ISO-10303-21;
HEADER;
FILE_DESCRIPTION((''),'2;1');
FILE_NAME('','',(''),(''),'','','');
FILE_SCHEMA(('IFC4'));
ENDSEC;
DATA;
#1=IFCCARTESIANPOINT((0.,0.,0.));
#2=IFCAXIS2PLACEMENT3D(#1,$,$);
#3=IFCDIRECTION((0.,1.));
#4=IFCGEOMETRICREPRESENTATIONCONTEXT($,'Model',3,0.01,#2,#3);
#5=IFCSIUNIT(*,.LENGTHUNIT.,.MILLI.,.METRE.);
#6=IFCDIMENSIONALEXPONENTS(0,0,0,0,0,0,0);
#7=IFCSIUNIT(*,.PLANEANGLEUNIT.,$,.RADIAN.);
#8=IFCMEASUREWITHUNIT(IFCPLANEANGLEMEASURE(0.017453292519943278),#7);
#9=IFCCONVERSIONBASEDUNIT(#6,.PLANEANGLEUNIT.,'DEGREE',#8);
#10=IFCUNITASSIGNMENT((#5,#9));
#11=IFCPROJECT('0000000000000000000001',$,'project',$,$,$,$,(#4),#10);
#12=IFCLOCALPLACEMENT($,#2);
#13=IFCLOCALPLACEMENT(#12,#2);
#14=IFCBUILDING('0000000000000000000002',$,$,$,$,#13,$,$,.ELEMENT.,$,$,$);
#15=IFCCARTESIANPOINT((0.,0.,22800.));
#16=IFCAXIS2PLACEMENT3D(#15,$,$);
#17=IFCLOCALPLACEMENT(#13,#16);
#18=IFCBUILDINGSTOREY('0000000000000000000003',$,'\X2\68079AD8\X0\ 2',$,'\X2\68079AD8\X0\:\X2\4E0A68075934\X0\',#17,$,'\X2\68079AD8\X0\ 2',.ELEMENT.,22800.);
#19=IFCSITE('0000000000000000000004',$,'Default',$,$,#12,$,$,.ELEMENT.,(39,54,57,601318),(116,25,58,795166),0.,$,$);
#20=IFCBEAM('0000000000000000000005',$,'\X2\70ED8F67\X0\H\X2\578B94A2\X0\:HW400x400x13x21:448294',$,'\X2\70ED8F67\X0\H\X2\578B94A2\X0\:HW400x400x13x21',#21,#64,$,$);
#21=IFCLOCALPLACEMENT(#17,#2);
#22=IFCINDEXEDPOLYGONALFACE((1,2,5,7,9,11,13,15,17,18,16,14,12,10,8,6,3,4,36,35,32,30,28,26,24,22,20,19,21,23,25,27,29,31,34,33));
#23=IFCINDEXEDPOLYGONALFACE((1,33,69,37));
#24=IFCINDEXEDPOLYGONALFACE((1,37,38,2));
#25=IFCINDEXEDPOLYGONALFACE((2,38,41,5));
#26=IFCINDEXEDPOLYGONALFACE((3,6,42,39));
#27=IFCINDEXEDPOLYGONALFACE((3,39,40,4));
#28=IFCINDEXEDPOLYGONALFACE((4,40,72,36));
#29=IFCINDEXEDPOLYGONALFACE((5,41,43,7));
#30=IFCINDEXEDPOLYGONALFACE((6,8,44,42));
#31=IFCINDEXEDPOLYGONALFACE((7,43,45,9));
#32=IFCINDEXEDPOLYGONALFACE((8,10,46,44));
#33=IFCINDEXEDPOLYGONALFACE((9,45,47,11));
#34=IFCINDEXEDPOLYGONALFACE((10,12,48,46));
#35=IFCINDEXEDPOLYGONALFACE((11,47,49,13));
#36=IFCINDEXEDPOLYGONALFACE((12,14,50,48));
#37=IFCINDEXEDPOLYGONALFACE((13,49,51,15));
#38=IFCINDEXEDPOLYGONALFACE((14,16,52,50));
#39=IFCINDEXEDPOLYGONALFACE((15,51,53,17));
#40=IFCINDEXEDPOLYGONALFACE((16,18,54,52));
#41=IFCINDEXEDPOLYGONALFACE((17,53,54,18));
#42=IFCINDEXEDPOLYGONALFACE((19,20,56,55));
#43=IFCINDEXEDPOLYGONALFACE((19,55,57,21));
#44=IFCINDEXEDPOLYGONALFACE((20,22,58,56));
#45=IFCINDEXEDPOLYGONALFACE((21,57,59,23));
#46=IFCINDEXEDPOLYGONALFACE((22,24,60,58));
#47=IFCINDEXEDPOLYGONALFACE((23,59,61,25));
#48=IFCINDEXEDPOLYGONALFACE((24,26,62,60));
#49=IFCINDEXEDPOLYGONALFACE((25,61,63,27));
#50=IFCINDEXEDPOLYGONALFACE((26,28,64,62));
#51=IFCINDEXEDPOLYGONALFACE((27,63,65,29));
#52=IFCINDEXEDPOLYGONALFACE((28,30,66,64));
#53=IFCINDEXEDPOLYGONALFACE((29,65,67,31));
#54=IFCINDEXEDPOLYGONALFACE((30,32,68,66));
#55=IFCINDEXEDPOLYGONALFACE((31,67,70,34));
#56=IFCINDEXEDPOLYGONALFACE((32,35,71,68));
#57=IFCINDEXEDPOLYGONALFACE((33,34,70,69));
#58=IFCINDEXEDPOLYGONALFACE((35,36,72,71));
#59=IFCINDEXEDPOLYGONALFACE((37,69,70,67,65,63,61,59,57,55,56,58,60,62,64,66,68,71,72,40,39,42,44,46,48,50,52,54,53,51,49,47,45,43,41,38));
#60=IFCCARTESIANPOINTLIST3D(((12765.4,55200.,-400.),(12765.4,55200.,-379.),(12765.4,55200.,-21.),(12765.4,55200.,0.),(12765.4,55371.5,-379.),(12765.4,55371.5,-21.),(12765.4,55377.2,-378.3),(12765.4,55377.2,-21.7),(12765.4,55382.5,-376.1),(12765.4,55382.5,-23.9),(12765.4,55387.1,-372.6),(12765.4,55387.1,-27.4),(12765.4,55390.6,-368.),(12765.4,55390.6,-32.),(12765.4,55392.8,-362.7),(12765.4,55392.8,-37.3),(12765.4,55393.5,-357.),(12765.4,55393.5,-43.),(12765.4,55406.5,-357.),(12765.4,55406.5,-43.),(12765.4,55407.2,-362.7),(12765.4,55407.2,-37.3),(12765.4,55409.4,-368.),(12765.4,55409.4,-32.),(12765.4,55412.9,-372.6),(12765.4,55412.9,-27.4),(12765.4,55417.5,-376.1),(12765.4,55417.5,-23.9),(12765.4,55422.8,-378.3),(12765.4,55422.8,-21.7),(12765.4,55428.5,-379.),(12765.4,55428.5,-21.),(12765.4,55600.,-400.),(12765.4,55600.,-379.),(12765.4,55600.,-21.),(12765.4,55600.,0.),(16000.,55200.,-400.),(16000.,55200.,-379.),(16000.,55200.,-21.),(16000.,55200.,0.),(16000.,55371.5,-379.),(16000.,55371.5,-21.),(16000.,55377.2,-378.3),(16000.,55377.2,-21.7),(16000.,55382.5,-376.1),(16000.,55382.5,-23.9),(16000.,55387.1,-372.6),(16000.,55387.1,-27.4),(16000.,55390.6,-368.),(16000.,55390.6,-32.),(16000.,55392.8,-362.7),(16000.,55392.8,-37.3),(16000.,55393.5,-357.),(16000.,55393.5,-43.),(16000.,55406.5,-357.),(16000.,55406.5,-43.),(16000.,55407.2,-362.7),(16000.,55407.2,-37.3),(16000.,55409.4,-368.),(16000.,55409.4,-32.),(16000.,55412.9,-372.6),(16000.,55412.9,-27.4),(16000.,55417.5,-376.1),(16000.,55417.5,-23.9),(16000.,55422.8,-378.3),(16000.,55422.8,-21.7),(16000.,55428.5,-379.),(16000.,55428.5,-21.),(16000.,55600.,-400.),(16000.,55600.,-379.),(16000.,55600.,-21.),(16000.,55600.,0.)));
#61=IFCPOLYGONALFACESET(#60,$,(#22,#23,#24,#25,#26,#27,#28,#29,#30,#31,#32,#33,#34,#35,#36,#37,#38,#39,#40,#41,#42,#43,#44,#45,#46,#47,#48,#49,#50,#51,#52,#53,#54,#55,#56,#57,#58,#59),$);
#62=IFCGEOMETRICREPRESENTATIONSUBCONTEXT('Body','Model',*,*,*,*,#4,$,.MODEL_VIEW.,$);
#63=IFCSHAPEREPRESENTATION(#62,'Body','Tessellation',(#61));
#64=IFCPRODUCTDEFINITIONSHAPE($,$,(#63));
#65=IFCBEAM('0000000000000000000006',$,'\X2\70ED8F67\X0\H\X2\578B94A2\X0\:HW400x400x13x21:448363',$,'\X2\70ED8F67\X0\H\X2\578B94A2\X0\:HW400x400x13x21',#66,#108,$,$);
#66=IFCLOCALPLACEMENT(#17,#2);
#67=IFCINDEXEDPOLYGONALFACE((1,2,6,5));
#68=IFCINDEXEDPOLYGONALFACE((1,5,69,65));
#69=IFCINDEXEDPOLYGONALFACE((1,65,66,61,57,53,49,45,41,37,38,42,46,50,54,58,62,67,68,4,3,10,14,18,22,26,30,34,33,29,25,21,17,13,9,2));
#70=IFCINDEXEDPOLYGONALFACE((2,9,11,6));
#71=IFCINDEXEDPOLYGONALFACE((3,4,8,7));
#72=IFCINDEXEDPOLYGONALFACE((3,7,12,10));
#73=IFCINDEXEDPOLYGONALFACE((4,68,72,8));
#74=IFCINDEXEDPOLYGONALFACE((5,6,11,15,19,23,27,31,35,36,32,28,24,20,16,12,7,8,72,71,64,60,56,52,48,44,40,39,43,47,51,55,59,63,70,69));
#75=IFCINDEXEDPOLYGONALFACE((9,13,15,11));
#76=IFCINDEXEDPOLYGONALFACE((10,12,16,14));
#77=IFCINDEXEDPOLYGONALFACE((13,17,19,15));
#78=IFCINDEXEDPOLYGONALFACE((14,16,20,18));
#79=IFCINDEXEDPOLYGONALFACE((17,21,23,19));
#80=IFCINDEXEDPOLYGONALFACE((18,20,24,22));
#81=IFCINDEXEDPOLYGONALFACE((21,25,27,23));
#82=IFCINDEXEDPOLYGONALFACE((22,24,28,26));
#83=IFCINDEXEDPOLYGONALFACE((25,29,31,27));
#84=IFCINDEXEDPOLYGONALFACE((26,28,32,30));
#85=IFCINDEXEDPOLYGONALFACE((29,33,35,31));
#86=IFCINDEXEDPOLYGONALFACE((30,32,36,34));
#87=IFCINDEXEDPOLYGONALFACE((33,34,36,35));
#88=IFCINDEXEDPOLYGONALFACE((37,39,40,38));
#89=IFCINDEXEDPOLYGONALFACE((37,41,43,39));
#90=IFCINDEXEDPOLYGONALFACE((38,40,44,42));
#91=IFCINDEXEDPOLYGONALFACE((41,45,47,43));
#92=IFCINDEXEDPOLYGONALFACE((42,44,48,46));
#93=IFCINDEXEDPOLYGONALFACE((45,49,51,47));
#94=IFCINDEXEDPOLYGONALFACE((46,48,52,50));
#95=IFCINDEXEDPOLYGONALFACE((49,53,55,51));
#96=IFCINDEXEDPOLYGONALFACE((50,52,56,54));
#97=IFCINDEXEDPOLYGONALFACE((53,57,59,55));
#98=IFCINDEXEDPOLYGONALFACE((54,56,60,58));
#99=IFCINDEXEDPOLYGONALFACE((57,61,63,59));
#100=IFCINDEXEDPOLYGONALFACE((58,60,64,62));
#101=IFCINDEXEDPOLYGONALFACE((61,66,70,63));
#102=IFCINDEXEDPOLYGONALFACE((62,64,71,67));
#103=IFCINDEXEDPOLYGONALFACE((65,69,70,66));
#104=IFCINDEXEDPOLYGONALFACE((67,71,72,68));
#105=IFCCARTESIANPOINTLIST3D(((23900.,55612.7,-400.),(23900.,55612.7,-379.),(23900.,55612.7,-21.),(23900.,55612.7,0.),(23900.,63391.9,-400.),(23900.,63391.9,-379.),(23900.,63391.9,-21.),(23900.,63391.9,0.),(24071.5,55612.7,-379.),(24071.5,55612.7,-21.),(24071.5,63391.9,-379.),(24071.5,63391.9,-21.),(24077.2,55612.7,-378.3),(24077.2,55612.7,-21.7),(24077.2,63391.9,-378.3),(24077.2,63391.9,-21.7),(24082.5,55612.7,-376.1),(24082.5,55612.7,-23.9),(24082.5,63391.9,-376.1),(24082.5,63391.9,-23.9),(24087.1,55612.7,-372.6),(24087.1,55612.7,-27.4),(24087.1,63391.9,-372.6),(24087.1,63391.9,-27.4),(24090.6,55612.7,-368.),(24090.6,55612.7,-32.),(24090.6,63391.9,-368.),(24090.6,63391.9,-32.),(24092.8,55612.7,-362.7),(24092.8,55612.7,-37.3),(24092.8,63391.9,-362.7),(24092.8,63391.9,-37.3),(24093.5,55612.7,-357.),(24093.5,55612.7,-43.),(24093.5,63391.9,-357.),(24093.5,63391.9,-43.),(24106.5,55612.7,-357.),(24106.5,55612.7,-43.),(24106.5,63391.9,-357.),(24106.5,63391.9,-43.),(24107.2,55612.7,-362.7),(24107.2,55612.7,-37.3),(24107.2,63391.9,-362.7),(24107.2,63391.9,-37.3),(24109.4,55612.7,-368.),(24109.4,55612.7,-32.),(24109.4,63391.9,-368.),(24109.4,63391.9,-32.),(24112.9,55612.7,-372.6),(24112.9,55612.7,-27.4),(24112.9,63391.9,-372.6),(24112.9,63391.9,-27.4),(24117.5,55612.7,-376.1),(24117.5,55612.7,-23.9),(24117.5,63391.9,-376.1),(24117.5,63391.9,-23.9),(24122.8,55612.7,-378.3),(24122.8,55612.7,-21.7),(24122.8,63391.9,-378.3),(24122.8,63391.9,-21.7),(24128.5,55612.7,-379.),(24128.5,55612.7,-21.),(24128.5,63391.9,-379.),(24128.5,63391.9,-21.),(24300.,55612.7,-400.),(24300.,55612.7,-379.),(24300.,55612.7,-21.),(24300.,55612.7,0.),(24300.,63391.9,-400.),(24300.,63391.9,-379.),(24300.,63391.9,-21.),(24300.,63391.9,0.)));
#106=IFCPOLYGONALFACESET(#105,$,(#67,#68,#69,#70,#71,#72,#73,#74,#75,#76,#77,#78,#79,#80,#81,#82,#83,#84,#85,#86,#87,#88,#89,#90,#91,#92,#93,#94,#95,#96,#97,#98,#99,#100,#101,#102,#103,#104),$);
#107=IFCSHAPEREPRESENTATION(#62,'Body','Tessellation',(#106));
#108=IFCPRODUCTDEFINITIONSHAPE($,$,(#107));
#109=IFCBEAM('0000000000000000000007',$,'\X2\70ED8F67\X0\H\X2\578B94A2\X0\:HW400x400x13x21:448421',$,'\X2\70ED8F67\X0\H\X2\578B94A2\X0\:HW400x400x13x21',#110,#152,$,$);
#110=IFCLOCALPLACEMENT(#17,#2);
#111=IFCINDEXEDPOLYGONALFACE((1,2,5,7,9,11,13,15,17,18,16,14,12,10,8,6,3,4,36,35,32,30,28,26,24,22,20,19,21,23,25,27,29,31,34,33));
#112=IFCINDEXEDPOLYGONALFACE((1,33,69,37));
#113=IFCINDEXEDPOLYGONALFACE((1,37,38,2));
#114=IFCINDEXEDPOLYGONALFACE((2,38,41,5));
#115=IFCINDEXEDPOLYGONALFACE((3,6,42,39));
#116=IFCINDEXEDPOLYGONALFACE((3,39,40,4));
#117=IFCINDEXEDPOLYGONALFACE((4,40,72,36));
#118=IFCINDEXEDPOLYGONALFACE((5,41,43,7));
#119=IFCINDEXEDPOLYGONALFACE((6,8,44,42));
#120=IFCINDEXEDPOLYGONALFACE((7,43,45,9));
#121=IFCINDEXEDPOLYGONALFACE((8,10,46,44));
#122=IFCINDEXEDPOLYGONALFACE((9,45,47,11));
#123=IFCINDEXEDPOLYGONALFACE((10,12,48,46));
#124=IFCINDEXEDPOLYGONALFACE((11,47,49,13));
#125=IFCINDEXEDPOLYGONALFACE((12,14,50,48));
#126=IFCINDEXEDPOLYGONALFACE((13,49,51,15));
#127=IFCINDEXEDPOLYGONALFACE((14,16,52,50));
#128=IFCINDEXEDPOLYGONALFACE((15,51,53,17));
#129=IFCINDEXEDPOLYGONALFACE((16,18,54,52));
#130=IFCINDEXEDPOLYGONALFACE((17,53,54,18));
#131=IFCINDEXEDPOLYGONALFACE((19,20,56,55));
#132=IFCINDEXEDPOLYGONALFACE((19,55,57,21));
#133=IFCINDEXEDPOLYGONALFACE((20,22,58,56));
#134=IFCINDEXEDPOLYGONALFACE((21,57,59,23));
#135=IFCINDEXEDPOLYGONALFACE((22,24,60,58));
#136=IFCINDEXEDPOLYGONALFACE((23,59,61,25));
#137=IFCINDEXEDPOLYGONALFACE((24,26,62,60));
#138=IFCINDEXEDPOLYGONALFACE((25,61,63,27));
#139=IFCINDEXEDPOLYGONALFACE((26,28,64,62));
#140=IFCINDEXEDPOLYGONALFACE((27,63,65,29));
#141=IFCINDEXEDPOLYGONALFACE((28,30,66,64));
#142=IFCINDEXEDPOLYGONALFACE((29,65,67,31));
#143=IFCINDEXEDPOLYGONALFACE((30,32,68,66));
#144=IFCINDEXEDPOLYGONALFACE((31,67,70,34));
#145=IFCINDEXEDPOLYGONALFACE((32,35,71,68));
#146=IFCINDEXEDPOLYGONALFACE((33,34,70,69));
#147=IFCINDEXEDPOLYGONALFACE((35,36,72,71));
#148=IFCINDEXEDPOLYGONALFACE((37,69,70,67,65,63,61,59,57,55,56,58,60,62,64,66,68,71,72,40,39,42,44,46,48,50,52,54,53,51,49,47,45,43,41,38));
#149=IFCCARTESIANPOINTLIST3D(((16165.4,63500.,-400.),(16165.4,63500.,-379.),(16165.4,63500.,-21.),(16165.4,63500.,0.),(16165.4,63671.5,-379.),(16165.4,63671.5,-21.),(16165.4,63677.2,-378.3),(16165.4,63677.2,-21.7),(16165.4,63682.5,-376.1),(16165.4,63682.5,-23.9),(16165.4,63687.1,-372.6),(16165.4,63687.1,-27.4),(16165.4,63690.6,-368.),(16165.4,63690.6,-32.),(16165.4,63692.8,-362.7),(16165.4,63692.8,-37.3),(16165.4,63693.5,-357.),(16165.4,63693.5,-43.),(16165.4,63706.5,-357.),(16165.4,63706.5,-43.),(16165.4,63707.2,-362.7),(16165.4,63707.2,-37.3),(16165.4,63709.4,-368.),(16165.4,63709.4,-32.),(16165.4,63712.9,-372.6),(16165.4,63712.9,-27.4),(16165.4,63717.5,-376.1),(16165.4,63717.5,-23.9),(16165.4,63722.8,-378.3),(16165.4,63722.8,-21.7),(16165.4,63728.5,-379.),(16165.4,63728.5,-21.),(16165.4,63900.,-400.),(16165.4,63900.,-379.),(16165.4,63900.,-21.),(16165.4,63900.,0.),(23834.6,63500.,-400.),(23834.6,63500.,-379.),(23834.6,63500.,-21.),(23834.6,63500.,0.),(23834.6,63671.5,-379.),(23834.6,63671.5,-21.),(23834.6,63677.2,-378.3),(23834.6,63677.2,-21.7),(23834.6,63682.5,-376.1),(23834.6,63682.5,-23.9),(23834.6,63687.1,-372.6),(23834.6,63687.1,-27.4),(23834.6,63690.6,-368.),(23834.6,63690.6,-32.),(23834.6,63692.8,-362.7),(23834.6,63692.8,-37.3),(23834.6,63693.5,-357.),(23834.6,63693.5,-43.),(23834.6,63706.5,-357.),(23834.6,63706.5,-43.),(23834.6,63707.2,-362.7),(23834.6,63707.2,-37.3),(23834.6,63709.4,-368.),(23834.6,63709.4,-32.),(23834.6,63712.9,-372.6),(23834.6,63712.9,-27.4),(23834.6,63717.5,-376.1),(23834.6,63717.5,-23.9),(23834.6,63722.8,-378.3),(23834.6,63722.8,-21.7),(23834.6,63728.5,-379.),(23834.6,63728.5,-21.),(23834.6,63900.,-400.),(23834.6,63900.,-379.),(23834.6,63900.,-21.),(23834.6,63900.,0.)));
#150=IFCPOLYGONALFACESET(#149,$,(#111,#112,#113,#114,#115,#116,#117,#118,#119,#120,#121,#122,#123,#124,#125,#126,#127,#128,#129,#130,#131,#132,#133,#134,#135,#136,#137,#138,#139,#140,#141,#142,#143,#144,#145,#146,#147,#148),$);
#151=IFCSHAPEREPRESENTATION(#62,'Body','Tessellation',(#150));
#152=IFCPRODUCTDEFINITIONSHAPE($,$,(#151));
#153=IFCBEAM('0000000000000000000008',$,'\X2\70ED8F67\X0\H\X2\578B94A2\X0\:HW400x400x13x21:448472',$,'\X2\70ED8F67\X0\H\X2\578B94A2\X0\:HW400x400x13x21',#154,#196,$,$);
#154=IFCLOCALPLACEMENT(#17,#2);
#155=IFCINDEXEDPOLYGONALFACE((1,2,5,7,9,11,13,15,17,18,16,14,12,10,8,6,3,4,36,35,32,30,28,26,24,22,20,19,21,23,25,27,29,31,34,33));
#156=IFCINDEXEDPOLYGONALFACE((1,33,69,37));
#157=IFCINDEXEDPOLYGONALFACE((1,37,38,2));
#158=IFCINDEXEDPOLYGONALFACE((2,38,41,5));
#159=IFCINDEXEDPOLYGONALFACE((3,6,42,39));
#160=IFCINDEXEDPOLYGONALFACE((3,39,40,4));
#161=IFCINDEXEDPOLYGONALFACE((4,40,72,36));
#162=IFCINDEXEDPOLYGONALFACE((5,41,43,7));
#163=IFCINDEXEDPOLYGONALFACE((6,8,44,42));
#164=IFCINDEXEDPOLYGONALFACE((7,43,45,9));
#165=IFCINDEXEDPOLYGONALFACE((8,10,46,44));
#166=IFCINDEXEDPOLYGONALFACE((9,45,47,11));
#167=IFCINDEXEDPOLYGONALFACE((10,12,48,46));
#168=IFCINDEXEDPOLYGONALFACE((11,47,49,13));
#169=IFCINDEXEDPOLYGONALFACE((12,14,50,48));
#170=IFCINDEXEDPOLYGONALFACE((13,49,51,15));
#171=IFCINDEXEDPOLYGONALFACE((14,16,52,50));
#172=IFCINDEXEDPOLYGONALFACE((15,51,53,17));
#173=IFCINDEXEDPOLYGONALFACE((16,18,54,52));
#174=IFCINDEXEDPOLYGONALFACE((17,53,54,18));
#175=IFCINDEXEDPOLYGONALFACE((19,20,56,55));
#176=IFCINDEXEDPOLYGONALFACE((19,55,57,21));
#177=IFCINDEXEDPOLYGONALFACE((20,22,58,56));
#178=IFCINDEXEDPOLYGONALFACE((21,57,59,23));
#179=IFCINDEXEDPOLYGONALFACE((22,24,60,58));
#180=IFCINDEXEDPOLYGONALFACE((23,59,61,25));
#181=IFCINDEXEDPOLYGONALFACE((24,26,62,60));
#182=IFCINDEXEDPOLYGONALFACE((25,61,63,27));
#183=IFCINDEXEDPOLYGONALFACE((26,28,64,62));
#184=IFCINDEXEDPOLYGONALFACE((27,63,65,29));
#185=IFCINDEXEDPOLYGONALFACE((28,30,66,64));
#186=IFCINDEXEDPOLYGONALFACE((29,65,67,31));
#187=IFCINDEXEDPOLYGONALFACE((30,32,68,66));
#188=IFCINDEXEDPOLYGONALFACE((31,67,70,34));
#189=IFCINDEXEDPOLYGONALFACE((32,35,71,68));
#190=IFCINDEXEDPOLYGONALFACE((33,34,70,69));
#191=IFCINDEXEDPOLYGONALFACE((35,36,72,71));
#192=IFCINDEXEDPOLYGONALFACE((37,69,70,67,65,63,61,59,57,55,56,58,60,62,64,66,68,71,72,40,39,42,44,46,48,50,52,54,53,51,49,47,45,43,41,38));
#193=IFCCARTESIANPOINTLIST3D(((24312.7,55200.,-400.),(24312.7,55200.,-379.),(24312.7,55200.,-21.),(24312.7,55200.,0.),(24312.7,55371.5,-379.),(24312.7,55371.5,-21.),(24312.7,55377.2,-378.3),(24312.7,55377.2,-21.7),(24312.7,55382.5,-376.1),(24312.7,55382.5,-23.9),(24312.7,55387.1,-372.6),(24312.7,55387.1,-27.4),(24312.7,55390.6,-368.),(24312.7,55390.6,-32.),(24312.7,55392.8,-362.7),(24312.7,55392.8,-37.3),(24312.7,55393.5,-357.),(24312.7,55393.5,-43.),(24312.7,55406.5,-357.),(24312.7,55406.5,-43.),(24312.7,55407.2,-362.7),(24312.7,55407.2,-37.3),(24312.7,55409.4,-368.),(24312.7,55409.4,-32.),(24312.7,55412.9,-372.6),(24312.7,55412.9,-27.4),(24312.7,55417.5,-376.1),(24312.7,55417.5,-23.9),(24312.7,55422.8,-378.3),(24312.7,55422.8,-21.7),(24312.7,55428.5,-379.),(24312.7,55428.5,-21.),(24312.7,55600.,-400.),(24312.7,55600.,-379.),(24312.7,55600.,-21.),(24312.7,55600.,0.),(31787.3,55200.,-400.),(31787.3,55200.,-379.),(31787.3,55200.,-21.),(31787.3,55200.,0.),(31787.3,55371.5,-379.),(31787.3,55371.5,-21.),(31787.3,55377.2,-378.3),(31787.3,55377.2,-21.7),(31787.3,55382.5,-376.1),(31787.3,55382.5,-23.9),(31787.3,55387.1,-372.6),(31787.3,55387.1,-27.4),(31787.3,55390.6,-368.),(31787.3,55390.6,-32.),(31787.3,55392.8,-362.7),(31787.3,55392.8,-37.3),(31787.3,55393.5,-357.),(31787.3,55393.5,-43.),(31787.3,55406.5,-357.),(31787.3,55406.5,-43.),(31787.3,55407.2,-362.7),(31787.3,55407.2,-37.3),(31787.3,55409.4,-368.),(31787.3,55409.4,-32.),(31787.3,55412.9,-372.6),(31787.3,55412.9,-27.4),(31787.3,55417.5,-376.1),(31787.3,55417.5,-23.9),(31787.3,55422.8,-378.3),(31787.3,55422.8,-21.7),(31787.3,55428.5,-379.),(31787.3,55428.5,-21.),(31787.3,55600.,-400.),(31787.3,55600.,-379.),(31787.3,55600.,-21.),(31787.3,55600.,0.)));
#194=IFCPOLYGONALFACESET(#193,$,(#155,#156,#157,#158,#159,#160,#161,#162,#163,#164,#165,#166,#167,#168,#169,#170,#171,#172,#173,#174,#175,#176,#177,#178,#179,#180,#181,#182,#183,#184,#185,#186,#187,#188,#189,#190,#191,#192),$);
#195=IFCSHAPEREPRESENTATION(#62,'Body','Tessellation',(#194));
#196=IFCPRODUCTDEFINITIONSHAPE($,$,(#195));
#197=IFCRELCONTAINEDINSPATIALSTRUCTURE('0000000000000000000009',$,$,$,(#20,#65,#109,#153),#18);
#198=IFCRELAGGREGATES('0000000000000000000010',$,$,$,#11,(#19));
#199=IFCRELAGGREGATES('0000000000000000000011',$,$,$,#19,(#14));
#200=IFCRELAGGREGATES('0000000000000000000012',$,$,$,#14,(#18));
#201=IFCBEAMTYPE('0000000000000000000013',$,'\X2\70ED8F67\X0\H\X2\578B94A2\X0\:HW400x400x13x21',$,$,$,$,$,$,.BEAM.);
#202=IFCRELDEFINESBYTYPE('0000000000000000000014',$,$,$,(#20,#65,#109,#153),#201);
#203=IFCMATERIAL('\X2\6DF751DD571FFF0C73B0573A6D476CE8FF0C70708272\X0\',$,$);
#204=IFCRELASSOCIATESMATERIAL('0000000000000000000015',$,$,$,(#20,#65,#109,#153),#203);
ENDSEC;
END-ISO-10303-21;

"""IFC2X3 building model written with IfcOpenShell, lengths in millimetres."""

from ifc_helpers import new_model, entity, si_unit, converted_unit, direction, frame, frame_2d, origin, place, context, subcontext, project, spatial, i_section, extrude, material, type_object, element, save


model = new_model("IFC2X3")

# Units and contexts
model_context = context("Model", 3, precision=0.01, world=origin(), true_north=direction((0.0, 1.0)))
body_context = subcontext(model_context, "Body", "Model", "MODEL_VIEW")
ifc_project = project(units=[si_unit("LENGTHUNIT", "METRE", prefix="MILLI"), converted_unit("PLANEANGLEUNIT", "DEGREE", entity("IfcPlaneAngleMeasure", 0.017453292519943278), si_unit("PLANEANGLEUNIT", "RADIAN"), dimensions=[0, 0, 0, 0, 0, 0, 0])], contexts=[model_context])

# Site, building, storey
site_placement = place(None, origin())
site = spatial("IfcSite", under=ifc_project, at=site_placement, Name="Default", CompositionType="ELEMENT", RefLatitude=(39, 54, 57, 601318), RefLongitude=(116, 25, 58, 795166), RefElevation=0.0)
building_placement = place(site_placement, origin())
building = spatial("IfcBuilding", under=site, at=building_placement, CompositionType="ELEMENT")
storey_placement = place(building_placement, frame((0.0, 0.0, 22800.0)))
storey = spatial("IfcBuildingStorey", under=building, at=storey_placement, Name="标高 2", ObjectType="标高:上标头", LongName="标高 2", CompositionType="ELEMENT", Elevation=22800.0)

# Beams
ifc_material = material(Name="混凝土，现场浇注，灰色")
beam_type = type_object("IfcBeamType", Name="热轧H型钢:HW400x400x13x21", PredefinedType="BEAM")
beam_1_placement = place(storey_placement, frame((12550.0, 55400.0, 0.0)))
element("IfcBeam", 1, at=beam_1_placement, inside=storey, type_object=beam_type, material=ifc_material, Name="热轧H型钢:HW400x400x13x21:448294", ObjectType="热轧H型钢:HW400x400x13x21", context=body_context, shape_type="SweptSolid", body=[
    extrude(i_section(OverallWidth=400.0, OverallDepth=400.0, WebThickness=13.0, FlangeThickness=21.0, FilletRadius=22.0, at=frame_2d((0.0, 0.0), x_axis=(0.0, 1.0))), frame((215.4, 0.0, -200.0), z_axis=(1.0, 0.0, 0.0), x_axis=(0.0, 0.0, -1.0)), (0.0, 0.0, 1.0), 3234.6),
])
beam_2_placement = place(storey_placement, frame((24100.0, 55400.0, 0.0), z_axis=(0.0, 0.0, 1.0), x_axis=(0.0, 1.0, 0.0)))
element("IfcBeam", 2, at=beam_2_placement, inside=storey, type_object=beam_type, material=ifc_material, Name="热轧H型钢:HW400x400x13x21:448363", ObjectType="热轧H型钢:HW400x400x13x21", context=body_context, shape_type="SweptSolid", body=[
    extrude(i_section(OverallWidth=400.0, OverallDepth=400.0, WebThickness=13.0, FlangeThickness=21.0, FilletRadius=22.0, at=frame_2d((0.0, 0.0), x_axis=(0.0, 1.0))), frame((212.7, 0.0, -200.0), z_axis=(1.0, 0.0, 0.0), x_axis=(0.0, 0.0, -1.0)), (0.0, 0.0, 1.0), 7779.2),
])
beam_3_placement = place(storey_placement, frame((16000.0, 63700.0, 0.0)))
element("IfcBeam", 3, at=beam_3_placement, inside=storey, type_object=beam_type, material=ifc_material, Name="热轧H型钢:HW400x400x13x21:448421", ObjectType="热轧H型钢:HW400x400x13x21", context=body_context, shape_type="SweptSolid", body=[
    extrude(i_section(OverallWidth=400.0, OverallDepth=400.0, WebThickness=13.0, FlangeThickness=21.0, FilletRadius=22.0, at=frame_2d((0.0, 0.0), x_axis=(0.0, 1.0))), frame((165.4, 0.0, -200.0), z_axis=(1.0, 0.0, 0.0), x_axis=(0.0, 0.0, -1.0)), (0.0, 0.0, 1.0), 7669.2),
])
beam_4_placement = place(storey_placement, frame((24100.0, 55400.0, 0.0)))
element("IfcBeam", 4, at=beam_4_placement, inside=storey, type_object=beam_type, material=ifc_material, Name="热轧H型钢:HW400x400x13x21:448472", ObjectType="热轧H型钢:HW400x400x13x21", context=body_context, shape_type="SweptSolid", body=[
    extrude(i_section(OverallWidth=400.0, OverallDepth=400.0, WebThickness=13.0, FlangeThickness=21.0, FilletRadius=22.0, at=frame_2d((0.0, 0.0), x_axis=(0.0, 1.0))), frame((212.7, 0.0, -200.0), z_axis=(1.0, 0.0, 0.0), x_axis=(0.0, 0.0, -1.0)), (0.0, 0.0, 1.0), 7474.6),
])

save(model, "model.ifc")
